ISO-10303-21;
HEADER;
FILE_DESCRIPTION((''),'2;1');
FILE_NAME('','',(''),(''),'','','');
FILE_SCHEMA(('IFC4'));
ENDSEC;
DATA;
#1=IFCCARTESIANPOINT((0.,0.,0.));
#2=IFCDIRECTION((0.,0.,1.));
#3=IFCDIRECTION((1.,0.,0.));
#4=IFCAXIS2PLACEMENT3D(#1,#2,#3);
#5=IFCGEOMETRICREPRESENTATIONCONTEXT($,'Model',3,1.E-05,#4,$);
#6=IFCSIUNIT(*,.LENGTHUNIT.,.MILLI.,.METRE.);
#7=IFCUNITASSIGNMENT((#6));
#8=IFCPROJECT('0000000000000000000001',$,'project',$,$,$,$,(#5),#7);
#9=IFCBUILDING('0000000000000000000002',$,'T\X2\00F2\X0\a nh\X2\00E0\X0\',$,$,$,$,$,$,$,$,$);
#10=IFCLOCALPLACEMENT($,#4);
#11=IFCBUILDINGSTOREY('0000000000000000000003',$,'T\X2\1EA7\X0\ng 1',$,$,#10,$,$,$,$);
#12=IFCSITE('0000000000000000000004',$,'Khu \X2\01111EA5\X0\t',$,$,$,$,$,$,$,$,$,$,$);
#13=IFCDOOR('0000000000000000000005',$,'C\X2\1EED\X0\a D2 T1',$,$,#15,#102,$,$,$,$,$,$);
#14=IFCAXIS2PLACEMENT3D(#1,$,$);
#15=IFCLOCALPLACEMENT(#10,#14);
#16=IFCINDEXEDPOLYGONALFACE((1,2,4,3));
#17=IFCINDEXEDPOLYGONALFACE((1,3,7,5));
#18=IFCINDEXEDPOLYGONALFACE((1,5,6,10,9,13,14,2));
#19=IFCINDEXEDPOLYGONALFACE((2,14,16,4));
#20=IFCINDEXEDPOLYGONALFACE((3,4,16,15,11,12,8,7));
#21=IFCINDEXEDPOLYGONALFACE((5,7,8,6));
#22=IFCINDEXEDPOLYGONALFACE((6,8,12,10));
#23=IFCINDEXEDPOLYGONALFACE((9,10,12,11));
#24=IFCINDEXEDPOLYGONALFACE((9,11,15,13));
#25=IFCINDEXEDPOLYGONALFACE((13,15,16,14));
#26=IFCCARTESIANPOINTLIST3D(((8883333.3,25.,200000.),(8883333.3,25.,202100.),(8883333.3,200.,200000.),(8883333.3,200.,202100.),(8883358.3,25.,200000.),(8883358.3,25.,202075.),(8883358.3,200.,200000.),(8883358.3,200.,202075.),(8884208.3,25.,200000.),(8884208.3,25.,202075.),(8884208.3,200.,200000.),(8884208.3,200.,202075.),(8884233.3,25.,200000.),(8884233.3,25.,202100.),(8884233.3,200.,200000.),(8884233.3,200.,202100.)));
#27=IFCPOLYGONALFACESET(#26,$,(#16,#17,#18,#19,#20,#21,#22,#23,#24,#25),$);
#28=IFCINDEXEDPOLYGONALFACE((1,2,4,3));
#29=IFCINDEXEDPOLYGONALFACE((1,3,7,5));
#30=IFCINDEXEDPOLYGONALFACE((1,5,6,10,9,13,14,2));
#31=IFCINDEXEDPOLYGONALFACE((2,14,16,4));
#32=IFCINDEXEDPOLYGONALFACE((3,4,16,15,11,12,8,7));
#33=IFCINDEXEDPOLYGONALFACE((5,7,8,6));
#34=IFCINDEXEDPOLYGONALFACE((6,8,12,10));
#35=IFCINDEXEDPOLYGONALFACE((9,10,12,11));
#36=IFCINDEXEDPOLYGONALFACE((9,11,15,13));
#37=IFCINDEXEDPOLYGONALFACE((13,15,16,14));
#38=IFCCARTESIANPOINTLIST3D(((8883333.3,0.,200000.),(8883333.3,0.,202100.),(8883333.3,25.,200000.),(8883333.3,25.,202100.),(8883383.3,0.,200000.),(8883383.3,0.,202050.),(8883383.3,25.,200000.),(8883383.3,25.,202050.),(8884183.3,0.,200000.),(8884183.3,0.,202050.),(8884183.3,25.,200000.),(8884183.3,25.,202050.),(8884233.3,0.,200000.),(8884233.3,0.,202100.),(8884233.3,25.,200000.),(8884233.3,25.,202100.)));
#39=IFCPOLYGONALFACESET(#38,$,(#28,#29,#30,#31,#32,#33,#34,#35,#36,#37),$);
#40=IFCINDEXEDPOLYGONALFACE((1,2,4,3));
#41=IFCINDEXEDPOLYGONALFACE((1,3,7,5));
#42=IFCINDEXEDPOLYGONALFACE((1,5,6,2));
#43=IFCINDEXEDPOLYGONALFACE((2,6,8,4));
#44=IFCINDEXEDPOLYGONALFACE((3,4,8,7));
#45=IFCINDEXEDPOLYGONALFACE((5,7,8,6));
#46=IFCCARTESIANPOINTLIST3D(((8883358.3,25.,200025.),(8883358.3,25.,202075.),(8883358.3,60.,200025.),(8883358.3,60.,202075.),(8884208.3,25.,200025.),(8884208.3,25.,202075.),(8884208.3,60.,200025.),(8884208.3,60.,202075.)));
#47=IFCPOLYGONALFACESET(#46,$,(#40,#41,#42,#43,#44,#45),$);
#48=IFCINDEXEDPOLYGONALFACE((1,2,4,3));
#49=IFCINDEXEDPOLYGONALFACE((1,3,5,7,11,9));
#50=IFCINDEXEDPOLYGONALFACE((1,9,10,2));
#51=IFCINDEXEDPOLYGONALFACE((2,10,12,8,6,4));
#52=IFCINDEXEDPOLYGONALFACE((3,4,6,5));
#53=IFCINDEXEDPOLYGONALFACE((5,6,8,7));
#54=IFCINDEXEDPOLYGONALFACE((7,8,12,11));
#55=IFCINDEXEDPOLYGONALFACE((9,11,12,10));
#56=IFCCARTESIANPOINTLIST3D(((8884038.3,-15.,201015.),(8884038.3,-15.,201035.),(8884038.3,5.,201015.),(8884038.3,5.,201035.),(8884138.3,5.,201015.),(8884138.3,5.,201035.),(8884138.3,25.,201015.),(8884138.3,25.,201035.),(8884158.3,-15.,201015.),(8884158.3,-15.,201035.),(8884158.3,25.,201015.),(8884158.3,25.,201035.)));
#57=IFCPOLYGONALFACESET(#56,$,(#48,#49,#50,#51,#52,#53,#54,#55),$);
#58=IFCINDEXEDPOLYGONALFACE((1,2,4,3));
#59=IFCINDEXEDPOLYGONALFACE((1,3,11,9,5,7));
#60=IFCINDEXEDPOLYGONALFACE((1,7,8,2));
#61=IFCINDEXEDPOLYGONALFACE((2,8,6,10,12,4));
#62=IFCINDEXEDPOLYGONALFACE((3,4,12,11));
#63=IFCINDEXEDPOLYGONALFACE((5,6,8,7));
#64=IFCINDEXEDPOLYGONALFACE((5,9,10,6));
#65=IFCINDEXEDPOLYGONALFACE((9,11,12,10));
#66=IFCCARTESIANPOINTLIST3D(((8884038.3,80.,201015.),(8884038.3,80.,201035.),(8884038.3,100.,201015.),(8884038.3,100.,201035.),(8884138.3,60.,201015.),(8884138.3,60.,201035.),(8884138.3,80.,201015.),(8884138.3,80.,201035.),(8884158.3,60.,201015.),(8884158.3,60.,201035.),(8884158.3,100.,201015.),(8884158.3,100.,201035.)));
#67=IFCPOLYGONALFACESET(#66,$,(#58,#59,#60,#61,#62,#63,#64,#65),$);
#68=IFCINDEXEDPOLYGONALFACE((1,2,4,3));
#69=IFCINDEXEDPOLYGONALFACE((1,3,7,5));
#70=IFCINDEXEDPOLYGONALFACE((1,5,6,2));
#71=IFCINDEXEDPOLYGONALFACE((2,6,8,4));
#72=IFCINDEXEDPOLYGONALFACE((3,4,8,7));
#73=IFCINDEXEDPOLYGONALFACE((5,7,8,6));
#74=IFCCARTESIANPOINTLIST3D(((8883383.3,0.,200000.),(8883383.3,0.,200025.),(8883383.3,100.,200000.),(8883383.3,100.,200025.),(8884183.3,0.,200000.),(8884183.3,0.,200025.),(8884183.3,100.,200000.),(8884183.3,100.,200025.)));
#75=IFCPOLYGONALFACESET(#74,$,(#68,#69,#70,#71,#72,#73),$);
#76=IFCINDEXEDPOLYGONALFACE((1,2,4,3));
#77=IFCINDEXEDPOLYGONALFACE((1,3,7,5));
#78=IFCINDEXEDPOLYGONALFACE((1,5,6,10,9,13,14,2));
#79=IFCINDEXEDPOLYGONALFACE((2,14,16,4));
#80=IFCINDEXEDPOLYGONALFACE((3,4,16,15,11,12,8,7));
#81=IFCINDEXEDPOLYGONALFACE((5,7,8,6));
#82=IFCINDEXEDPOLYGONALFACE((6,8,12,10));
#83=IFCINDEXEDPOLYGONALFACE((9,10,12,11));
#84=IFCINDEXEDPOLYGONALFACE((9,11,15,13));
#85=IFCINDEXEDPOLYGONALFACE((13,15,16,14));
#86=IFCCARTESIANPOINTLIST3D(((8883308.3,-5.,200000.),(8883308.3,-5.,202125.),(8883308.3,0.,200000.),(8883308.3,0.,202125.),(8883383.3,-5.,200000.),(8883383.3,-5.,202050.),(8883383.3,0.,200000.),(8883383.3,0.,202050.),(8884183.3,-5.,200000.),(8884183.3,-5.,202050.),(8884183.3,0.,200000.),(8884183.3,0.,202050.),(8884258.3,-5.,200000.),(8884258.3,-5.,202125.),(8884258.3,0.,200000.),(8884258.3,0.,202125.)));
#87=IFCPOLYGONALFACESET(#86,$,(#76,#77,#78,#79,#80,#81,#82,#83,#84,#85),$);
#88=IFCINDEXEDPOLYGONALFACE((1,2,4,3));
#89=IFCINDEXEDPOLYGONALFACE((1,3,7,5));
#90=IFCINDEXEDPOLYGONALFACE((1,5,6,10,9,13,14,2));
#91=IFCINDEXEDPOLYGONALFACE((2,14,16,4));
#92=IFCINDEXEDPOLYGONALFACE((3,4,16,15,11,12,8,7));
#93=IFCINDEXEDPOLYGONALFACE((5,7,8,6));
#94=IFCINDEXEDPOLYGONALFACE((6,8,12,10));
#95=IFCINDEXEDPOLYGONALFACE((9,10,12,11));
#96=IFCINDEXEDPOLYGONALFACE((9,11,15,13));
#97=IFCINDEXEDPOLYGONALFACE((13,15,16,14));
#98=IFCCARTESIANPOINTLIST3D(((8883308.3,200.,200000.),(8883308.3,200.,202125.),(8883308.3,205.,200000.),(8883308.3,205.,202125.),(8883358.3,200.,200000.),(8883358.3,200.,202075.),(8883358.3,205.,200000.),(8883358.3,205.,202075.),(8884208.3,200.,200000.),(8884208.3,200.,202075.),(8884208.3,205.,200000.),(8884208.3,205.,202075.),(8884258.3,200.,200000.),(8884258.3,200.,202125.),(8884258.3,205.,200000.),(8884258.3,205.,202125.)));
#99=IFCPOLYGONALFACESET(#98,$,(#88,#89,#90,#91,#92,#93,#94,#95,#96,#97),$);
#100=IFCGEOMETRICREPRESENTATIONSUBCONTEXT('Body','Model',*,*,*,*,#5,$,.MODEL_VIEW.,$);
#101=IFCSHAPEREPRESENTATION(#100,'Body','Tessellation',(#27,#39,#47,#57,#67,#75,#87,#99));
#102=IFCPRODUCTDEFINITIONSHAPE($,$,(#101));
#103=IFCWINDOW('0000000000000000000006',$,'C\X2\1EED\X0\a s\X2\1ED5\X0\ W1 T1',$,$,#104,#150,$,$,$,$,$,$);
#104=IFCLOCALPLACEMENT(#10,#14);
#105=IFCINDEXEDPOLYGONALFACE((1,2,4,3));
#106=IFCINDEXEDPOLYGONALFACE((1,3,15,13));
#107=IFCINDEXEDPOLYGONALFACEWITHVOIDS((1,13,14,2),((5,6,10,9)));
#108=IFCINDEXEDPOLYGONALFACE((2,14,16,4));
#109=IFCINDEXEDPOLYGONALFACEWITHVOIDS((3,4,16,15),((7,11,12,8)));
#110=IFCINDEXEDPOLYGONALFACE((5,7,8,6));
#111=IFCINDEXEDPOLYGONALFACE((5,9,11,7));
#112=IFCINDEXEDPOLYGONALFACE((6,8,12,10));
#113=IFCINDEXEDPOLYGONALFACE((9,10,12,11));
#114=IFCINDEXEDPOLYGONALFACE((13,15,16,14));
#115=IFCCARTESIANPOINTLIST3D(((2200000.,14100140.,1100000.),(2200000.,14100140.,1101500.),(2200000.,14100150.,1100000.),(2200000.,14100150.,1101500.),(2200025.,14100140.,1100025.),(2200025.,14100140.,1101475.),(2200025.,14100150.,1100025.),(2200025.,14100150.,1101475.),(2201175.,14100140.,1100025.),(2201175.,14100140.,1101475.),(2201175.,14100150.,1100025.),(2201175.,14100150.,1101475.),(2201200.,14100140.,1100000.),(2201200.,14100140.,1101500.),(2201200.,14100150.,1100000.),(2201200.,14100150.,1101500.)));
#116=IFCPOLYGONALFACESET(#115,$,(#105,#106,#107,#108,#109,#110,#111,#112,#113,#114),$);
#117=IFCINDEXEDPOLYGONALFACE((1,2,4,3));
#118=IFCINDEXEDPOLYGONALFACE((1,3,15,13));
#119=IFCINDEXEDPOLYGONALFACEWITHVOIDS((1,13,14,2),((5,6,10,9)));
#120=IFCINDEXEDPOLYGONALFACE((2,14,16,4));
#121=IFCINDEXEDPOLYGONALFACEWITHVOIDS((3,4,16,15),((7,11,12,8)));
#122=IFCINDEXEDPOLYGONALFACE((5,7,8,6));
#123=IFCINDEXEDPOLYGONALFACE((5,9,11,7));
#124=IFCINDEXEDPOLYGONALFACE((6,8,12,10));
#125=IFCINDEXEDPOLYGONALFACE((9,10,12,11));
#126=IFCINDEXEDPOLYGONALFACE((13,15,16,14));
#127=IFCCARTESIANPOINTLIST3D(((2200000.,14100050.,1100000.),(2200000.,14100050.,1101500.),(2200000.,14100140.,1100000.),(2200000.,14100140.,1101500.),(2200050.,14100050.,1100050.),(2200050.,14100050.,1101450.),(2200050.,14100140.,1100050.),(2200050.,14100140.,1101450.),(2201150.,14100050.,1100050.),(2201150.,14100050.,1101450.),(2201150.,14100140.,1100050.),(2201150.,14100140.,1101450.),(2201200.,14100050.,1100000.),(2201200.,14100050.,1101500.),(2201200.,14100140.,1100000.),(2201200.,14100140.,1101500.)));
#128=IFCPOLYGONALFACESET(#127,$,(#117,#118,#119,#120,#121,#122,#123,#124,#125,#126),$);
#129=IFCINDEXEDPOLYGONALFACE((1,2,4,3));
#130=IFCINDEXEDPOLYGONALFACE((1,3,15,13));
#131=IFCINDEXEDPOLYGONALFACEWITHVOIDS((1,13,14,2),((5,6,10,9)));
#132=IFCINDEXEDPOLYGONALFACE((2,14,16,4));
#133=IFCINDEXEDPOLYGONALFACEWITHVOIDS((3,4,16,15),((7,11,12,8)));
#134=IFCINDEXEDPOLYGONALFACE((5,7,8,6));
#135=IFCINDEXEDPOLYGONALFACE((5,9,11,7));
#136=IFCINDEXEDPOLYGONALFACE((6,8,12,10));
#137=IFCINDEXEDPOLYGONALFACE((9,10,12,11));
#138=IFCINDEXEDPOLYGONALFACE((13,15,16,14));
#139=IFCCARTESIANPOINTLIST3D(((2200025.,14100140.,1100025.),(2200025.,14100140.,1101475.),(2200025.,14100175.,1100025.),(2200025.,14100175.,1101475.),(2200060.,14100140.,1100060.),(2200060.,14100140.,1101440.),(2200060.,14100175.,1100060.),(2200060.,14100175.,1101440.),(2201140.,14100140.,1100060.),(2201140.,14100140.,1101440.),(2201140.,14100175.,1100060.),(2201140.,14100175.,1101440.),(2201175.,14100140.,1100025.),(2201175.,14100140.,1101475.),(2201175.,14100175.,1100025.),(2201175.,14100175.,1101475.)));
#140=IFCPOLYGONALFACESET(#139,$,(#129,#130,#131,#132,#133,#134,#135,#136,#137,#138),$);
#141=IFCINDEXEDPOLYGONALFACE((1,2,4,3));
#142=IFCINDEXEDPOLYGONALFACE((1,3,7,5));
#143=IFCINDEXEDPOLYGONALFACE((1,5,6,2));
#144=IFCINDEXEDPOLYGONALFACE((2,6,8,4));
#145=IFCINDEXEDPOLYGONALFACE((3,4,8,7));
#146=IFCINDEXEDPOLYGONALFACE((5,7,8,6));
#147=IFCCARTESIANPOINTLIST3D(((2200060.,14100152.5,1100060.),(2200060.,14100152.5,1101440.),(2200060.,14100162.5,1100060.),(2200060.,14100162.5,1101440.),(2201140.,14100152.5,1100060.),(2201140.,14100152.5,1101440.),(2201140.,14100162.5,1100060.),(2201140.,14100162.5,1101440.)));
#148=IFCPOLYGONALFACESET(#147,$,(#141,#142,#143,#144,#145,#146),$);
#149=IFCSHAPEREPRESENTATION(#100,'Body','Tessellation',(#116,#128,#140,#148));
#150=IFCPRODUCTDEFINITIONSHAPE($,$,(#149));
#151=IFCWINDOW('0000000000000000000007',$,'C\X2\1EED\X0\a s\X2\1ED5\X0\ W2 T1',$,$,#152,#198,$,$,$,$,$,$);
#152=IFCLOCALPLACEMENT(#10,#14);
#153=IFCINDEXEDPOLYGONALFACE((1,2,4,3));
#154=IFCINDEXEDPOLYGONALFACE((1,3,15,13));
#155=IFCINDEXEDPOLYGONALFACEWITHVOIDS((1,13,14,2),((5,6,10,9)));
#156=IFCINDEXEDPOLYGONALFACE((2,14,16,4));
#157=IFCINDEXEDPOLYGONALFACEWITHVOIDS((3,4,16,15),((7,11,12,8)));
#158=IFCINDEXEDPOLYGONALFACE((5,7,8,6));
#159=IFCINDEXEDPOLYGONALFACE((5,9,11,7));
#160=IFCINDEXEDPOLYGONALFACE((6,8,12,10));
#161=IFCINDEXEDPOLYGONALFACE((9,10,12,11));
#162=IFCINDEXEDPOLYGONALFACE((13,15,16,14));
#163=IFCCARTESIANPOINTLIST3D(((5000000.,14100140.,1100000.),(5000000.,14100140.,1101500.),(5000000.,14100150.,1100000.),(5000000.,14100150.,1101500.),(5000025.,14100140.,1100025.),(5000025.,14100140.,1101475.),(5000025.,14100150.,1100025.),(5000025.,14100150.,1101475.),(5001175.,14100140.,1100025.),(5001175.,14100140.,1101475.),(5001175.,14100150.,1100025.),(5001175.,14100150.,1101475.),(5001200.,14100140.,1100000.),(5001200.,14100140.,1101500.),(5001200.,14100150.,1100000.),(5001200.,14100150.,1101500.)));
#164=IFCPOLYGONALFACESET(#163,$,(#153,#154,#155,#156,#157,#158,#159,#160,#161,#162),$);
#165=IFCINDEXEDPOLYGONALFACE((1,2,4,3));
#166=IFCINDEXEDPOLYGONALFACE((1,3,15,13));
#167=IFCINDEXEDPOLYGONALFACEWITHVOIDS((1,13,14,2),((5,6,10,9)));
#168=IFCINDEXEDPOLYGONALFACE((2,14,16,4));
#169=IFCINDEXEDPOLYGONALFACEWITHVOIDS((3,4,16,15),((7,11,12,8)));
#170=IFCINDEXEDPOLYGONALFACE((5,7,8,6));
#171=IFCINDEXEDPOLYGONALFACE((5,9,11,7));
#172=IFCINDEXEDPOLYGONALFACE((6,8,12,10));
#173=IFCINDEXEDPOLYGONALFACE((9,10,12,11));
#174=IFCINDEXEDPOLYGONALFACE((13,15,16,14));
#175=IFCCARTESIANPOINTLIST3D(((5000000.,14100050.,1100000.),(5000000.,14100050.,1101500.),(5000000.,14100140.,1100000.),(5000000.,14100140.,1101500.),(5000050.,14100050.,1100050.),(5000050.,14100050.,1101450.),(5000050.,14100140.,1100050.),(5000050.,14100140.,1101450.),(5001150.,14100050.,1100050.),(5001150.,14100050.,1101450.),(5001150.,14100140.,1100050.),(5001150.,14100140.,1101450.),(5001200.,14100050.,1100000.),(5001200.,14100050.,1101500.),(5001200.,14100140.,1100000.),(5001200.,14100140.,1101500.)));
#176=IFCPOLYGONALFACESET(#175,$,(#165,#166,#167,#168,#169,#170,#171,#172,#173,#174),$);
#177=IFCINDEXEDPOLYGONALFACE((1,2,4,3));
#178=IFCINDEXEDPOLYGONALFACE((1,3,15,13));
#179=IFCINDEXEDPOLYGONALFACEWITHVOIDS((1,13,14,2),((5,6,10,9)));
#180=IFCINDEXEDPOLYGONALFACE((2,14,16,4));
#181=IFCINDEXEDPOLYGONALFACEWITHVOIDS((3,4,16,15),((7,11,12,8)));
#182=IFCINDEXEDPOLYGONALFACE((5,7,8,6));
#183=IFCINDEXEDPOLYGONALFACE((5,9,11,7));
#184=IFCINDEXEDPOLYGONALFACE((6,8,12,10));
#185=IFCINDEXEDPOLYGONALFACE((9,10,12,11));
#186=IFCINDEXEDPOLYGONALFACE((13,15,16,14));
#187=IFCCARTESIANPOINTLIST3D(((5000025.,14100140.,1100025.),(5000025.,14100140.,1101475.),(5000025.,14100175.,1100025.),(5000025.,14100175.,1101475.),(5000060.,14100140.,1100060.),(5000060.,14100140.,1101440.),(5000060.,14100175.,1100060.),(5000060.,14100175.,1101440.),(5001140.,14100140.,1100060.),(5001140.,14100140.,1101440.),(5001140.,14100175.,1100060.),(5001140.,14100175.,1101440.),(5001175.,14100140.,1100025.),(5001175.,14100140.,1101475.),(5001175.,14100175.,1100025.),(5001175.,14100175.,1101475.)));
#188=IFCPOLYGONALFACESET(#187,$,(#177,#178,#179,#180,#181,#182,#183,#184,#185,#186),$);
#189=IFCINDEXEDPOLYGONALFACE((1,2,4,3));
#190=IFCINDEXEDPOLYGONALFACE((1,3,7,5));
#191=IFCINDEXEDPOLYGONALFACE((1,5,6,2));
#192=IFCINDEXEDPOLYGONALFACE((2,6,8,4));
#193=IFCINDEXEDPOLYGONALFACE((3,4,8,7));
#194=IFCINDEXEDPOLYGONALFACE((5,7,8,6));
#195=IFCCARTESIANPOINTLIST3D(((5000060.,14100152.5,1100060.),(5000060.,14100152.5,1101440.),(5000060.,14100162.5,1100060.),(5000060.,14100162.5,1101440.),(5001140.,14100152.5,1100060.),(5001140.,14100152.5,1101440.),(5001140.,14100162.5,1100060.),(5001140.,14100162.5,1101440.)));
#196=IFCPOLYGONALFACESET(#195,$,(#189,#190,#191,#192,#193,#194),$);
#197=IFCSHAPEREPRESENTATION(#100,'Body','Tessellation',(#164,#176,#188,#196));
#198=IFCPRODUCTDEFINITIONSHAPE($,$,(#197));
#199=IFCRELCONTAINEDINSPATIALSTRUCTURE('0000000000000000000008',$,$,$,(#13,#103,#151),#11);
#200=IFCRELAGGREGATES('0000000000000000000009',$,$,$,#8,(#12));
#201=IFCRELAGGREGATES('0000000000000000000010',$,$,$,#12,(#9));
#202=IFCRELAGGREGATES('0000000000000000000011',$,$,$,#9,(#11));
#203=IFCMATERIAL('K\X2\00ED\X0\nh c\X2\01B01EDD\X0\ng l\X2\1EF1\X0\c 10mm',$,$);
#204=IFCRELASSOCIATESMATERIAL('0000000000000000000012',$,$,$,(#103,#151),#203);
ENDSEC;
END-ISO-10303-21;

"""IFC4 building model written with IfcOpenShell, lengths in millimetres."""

from ifc_helpers import new_model, si_unit, frame, origin_with_axes, place, context, subcontext, project, spatial, line, indexed_curve, outline, extrude, material, element, save


model = new_model("IFC4")

# Units and contexts
model_context = context("Model", 3, precision=1e-05, world=origin_with_axes())
body_context = subcontext(model_context, "Body", "Model", "MODEL_VIEW")
ifc_project = project(units=[si_unit("LENGTHUNIT", "METRE", prefix="MILLI")], contexts=[model_context])

# Site, building, storey
site = spatial("IfcSite", under=ifc_project, Name="Khu đất")
building = spatial("IfcBuilding", under=site, Name="Tòa nhà")
storey_placement = place(None, origin_with_axes())
storey = spatial("IfcBuildingStorey", under=building, at=storey_placement, Name="Tầng 1")

# Door
door_1_placement = place(storey_placement, frame((8883333.3, 0.0, 200000.0), z_axis=(0.0, 0.0, 1.0), x_axis=(1.0, 0.0, 0.0)))
element("IfcDoor", 1, at=door_1_placement, inside=storey, Name="Cửa D2 T1", context=body_context, shape_type="SolidModel", body=[
    extrude(outline(indexed_curve([(0.0, 0.0), (0.0, 2100.0), (900.0, 2100.0), (900.0, 0.0), (875.0, 0.0), (875.0, 2075.0), (25.0, 2075.0), (25.0, 0.0)], segments=[line(1, 2, 3, 4, 5, 6, 7, 8, 1)])), frame((0.0, 25.0, 0.0), z_axis=(0.0, -1.0, 0.0), x_axis=(1.0, 0.0, 0.0)), (0.0, 0.0, -1.0), 175.0),
    extrude(outline(indexed_curve([(0.0, 0.0), (0.0, 2100.0), (900.0, 2100.0), (900.0, 0.0), (850.0, 0.0), (850.0, 2050.0), (50.0, 2050.0), (50.0, 0.0)], segments=[line(1, 2, 3, 4, 5, 6, 7, 8, 1)])), frame((0.0, 0.0, 0.0), z_axis=(0.0, -1.0, 0.0), x_axis=(1.0, 0.0, 0.0)), (0.0, 0.0, -1.0), 25.0),
    extrude(outline(indexed_curve([(0.0, 0.0), (850.0, 0.0), (850.0, 35.0), (0.0, 35.0)], segments=[line(1, 2, 3, 4, 1)])), frame((25.0, 25.0, 25.0), z_axis=(0.0, 0.0, 1.0), x_axis=(1.0, 0.0, 0.0)), (0.0, 0.0, 1.0), 2050.0),
    extrude(outline(indexed_curve([(0.0, 0.0), (0.0, -40.0), (-120.0, -40.0), (-120.0, -20.0), (-20.0, -20.0), (-20.0, 0.0)], segments=[line(1, 2, 3, 4, 5, 6, 1)])), frame((825.0, 25.0, 1015.0), z_axis=(0.0, 0.0, 1.0), x_axis=(1.0, 0.0, 0.0)), (0.0, 0.0, 1.0), 20.0),
    extrude(outline(indexed_curve([(0.0, 0.0), (0.0, 40.0), (-120.0, 40.0), (-120.0, 20.0), (-20.0, 20.0), (-20.0, 0.0)], segments=[line(1, 2, 3, 4, 5, 6, 1)])), frame((825.0, 60.0, 1015.0), z_axis=(0.0, 0.0, 1.0), x_axis=(1.0, 0.0, 0.0)), (0.0, 0.0, 1.0), 20.0),
    extrude(outline(indexed_curve([(0.0, 0.0), (800.0, 0.0), (800.0, 100.0), (0.0, 100.0)], segments=[line(1, 2, 3, 4, 1)])), frame((50.0, 0.0, 0.0), z_axis=(0.0, 0.0, 1.0), x_axis=(1.0, 0.0, 0.0)), (0.0, 0.0, 1.0), 25.0),
    extrude(outline(indexed_curve([(0.0, 0.0), (0.0, 2125.0), (950.0, 2125.0), (950.0, 0.0), (875.0, 0.0), (875.0, 2050.0), (75.0, 2050.0), (75.0, 0.0)], segments=[line(1, 2, 3, 4, 5, 6, 7, 8, 1)])), frame((-25.0, -5.0, 0.0), z_axis=(0.0, -1.0, 0.0), x_axis=(1.0, 0.0, 0.0)), (0.0, 0.0, -1.0), 5.0),
    extrude(outline(indexed_curve([(0.0, 0.0), (0.0, 2125.0), (950.0, 2125.0), (950.0, 0.0), (900.0, 0.0), (900.0, 2075.0), (50.0, 2075.0), (50.0, 0.0)], segments=[line(1, 2, 3, 4, 5, 6, 7, 8, 1)])), frame((-25.0, 200.0, 0.0), z_axis=(0.0, -1.0, 0.0), x_axis=(1.0, 0.0, 0.0)), (0.0, 0.0, -1.0), 5.0),
])

# Windows
ifc_material_1 = material(Name="Kính cường lực 10mm")
for number, where, z_axis, x_axis, name in (
    (2, (2200000.0, 14100000.0, 1100000.0), (0.0, 0.0, 1.0), (1.0, 0.0, 0.0), "Cửa sổ W1 T1"),
    (3, (5000000.0, 14100000.0, 1100000.0), (0.0, 0.0, 1.0), (1.0, 0.0, 0.0), "Cửa sổ W2 T1"),
):
    element("IfcWindow", number, at=place(storey_placement, frame(where, z_axis=z_axis, x_axis=x_axis)), inside=storey, material=ifc_material_1, Name=name, context=body_context, shape_type="SolidModel", body=[
        extrude(outline(indexed_curve([(0.0, 0.0), (1200.0, 0.0), (1200.0, 1500.0), (0.0, 1500.0)], segments=[line(1, 2, 3, 4, 1)]), holes=[indexed_curve([(25.0, 25.0), (1175.0, 25.0), (1175.0, 1475.0), (25.0, 1475.0)], segments=[line(1, 2, 3, 4, 1)])]), frame((0.0, 140.0, 0.0), z_axis=(0.0, -1.0, 0.0), x_axis=(1.0, 0.0, 0.0)), (0.0, 0.0, -1.0), 10.0),
        extrude(outline(indexed_curve([(0.0, 0.0), (1200.0, 0.0), (1200.0, 1500.0), (0.0, 1500.0)], segments=[line(1, 2, 3, 4, 1)]), holes=[indexed_curve([(50.0, 50.0), (1150.0, 50.0), (1150.0, 1450.0), (50.0, 1450.0)], segments=[line(1, 2, 3, 4, 1)])]), frame((0.0, 50.0, 0.0), z_axis=(0.0, -1.0, 0.0), x_axis=(1.0, 0.0, 0.0)), (0.0, 0.0, -1.0), 90.0),
        extrude(outline(indexed_curve([(0.0, 0.0), (1150.0, 0.0), (1150.0, 1450.0), (0.0, 1450.0)], segments=[line(1, 2, 3, 4, 1)]), holes=[indexed_curve([(35.0, 35.0), (1115.0, 35.0), (1115.0, 1415.0), (35.0, 1415.0)], segments=[line(1, 2, 3, 4, 1)])]), frame((25.0, 140.0, 25.0), z_axis=(0.0, -1.0, 0.0), x_axis=(1.0, 0.0, 0.0)), (0.0, 0.0, -1.0), 35.0),
        extrude(outline(indexed_curve([(35.0, 35.0), (1115.0, 35.0), (1115.0, 1415.0), (35.0, 1415.0)], segments=[line(1, 2, 3, 4, 1)])), frame((25.0, 152.5, 25.0), z_axis=(0.0, -1.0, 0.0), x_axis=(1.0, 0.0, 0.0)), (0.0, 0.0, -1.0), 10.0),
    ])

save(model, "model.ifc")
